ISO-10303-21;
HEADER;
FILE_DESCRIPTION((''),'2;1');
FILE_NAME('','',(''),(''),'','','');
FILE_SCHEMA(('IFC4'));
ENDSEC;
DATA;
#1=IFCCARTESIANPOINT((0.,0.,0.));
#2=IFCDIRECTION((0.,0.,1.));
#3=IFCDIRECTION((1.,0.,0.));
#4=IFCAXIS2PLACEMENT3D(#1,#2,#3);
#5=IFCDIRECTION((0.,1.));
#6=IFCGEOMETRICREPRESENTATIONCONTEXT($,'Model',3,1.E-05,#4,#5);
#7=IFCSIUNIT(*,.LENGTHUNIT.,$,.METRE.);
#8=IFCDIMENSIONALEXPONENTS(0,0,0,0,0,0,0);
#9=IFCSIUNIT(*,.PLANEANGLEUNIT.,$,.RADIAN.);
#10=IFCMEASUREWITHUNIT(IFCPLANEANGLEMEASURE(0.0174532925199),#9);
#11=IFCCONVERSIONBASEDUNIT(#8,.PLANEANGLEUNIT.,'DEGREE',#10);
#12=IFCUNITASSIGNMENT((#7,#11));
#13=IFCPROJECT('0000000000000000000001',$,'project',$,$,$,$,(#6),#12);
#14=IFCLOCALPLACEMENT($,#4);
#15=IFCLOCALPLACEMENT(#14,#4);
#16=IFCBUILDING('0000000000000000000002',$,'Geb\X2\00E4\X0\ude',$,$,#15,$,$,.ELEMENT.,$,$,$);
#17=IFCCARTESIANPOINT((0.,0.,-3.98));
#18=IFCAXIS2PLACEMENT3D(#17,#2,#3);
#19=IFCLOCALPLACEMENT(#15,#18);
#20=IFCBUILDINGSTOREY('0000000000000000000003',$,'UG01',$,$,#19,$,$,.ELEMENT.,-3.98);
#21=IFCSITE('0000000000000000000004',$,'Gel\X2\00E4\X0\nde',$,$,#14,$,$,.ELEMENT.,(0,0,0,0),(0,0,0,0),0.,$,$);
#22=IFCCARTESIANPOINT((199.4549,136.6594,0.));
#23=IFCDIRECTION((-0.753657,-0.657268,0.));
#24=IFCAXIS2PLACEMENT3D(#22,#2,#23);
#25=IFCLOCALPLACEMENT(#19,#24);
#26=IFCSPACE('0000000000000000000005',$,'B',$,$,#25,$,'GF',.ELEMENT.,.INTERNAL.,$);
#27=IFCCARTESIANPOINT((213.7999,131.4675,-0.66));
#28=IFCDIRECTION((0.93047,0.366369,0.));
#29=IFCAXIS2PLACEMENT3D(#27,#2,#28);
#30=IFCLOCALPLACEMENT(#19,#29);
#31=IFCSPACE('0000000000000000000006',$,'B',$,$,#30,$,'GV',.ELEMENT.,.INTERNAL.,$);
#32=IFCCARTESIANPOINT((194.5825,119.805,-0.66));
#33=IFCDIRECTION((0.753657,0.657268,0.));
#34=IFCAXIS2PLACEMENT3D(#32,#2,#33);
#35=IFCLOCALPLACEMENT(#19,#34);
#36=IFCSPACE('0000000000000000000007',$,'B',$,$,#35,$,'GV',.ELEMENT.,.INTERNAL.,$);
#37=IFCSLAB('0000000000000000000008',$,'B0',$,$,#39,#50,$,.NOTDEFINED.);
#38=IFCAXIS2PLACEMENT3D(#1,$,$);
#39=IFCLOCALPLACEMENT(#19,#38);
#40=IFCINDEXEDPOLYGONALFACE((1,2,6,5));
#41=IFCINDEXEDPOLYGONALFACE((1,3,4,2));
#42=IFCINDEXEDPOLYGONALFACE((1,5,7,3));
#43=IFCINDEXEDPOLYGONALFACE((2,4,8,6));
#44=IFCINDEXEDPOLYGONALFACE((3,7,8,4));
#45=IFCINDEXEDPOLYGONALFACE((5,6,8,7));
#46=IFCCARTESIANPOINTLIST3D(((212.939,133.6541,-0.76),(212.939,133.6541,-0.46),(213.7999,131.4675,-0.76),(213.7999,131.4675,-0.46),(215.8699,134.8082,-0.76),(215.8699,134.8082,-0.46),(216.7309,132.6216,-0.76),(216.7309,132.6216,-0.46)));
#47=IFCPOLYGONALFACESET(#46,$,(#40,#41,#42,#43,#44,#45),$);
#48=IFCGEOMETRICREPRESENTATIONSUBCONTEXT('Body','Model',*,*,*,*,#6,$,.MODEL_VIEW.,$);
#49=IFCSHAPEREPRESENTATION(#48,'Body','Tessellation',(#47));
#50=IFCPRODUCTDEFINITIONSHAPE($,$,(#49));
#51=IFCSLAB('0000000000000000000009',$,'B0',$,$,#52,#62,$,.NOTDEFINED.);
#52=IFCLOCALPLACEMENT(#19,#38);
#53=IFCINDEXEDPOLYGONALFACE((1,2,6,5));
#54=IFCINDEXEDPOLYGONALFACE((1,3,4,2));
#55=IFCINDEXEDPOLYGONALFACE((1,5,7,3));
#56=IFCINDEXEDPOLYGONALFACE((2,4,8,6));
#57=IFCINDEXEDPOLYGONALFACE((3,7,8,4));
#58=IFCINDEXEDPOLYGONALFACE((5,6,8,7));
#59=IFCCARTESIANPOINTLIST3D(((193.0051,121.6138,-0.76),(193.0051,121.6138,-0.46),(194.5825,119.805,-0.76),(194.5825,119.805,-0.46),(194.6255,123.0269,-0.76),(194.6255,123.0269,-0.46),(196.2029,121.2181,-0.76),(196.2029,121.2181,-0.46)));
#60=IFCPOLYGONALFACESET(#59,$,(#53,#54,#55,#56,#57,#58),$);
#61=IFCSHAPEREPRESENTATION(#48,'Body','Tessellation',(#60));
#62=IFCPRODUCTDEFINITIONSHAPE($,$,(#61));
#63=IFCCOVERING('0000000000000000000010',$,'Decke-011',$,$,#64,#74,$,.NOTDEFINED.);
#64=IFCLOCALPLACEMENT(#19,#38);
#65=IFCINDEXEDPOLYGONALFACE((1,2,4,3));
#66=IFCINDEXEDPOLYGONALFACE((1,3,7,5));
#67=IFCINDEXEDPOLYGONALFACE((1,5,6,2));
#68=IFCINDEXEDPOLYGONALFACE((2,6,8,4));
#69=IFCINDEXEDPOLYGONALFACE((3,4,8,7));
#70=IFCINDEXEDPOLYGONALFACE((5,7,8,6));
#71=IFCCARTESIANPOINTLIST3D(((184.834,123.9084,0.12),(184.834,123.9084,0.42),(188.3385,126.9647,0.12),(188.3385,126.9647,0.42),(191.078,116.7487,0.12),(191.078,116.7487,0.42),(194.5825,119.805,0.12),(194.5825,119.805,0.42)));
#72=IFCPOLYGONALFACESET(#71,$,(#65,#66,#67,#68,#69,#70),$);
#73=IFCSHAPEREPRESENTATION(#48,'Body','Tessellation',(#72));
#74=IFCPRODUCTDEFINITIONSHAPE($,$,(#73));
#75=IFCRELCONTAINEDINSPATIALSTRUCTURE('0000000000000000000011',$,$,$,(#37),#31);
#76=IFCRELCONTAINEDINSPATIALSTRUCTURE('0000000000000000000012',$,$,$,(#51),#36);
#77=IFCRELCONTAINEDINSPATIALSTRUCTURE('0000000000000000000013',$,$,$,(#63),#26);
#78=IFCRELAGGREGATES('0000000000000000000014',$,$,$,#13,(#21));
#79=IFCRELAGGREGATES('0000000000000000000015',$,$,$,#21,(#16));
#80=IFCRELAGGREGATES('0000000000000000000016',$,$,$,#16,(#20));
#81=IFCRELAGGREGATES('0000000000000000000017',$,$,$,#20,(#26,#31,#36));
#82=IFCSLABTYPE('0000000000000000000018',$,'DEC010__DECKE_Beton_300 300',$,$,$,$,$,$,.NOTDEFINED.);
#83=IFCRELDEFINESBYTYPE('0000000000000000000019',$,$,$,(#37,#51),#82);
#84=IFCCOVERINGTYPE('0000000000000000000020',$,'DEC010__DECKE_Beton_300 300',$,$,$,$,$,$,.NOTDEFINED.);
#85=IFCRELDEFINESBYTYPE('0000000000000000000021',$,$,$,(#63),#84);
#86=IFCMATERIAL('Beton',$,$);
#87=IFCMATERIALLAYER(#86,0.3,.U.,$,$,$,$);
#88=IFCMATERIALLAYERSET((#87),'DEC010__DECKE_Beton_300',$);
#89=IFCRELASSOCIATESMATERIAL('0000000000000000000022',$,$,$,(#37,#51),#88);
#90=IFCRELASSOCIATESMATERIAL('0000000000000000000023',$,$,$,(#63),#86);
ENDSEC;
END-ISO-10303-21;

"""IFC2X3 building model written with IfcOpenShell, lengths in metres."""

from ifc_helpers import new_model, entity, si_unit, converted_unit, direction, frame, origin_with_axes, place, context, subcontext, project, spatial, polyline, outline, extrude, material, layer, layer_set, layer_usage, type_object, element, save


model = new_model("IFC2X3")

# Units and contexts
model_context = context("Model", 3, precision=1e-05, world=origin_with_axes(), true_north=direction((0.0, 1.0)))
body_context = subcontext(model_context, "Body", "Model", "MODEL_VIEW")
ifc_project = project(units=[si_unit("LENGTHUNIT", "METRE"), converted_unit("PLANEANGLEUNIT", "DEGREE", entity("IfcPlaneAngleMeasure", 0.0174532925199), si_unit("PLANEANGLEUNIT", "RADIAN"), dimensions=[0, 0, 0, 0, 0, 0, 0])], contexts=[model_context])

# Site, building, storey, space
site_placement = place(None, origin_with_axes())
site = spatial("IfcSite", under=ifc_project, at=site_placement, Name="Gelände", CompositionType="ELEMENT", RefLatitude=(0, 0, 0, 0), RefLongitude=(0, 0, 0, 0), RefElevation=0.0)
building_placement = place(site_placement, origin_with_axes())
building = spatial("IfcBuilding", under=site, at=building_placement, Name="Gebäude", CompositionType="ELEMENT")
storey_placement = place(building_placement, frame((0.0, 0.0, -3.98), z_axis=(0.0, 0.0, 1.0), x_axis=(1.0, 0.0, 0.0)))
storey = spatial("IfcBuildingStorey", under=building, at=storey_placement, Name="UG01", CompositionType="ELEMENT", Elevation=-3.98)
space_1_placement = place(storey_placement, frame((199.4549, 136.6594, 0.0), z_axis=(0.0, 0.0, 1.0), x_axis=(-0.753657, -0.657268, 0.0)))
space_1 = spatial("IfcSpace", under=storey, at=space_1_placement, Name="B", LongName="GF", CompositionType="ELEMENT", InteriorOrExteriorSpace="INTERNAL")

# Shared definitions
ifc_material_1 = material(Name="Beton")

# Shared definitions
space_2_placement = place(storey_placement, frame((213.7999, 131.4675, -0.66), z_axis=(0.0, 0.0, 1.0), x_axis=(0.93047, 0.366369, 0.0)))
space_2 = spatial("IfcSpace", under=storey, at=space_2_placement, Name="B", LongName="GV", CompositionType="ELEMENT", InteriorOrExteriorSpace="INTERNAL")

# Slab
ifc_layer_1 = layer(ifc_material_1, 0.3, ventilated="UNKNOWN")
ifc_layer_set_1 = layer_set([ifc_layer_1], Name="DEC010__DECKE_Beton_300")
ifc_layer_usage_1 = layer_usage(ifc_layer_set_1, "AXIS3", "NEGATIVE", 0.3)
slab_type_1 = type_object("IfcSlabType", Name="DEC010__DECKE_Beton_300 300", PredefinedType="NOTDEFINED")
slab_1_placement = place(space_2_placement, frame((3.15, 0.0, 0.2), z_axis=(0.0, 0.0, 1.0), x_axis=(0.93047, -0.366369, 0.0)))
element("IfcSlab", 1, at=slab_1_placement, inside=space_2, type_object=slab_type_1, material=ifc_layer_usage_1, Name="B0", PredefinedType="NOTDEFINED", context=body_context, shape_type="SweptSolid", body=[
    extrude(outline(polyline([(0.0, 0.0), (-0.861, 2.1866), (-3.792, 1.0325), (-2.931, -1.1541), (0.0, 0.0)])), frame((0.0, 0.0, -0.3), z_axis=(0.0, 0.0, 1.0), x_axis=(1.0, 0.0, 0.0)), (0.0, 0.0, 1.0), 0.3),
])

# Shared definitions
space_3_placement = place(storey_placement, frame((194.5825, 119.805, -0.66), z_axis=(0.0, 0.0, 1.0), x_axis=(0.753657, 0.657268, 0.0)))
space_3 = spatial("IfcSpace", under=storey, at=space_3_placement, Name="B", LongName="GV", CompositionType="ELEMENT", InteriorOrExteriorSpace="INTERNAL")

# Slab
slab_2_placement = place(space_3_placement, frame((0.0, 2.4, 0.2), z_axis=(0.0, 0.0, 1.0), x_axis=(0.753657, -0.657268, 0.0)))
element("IfcSlab", 2, at=slab_2_placement, inside=space_3, type_object=slab_type_1, material=ifc_layer_usage_1, Name="B0", PredefinedType="NOTDEFINED", context=body_context, shape_type="SweptSolid", body=[
    extrude(outline(polyline([(0.0, 0.0), (1.5774, -1.8088), (3.1978, -0.3956), (1.6204, 1.4131), (0.0, 0.0)])), frame((0.0, 0.0, -0.3), z_axis=(0.0, 0.0, 1.0), x_axis=(1.0, 0.0, 0.0)), (0.0, 0.0, 1.0), 0.3),
])

# Covering
covering_type = type_object("IfcCoveringType", Name="DEC010__DECKE_Beton_300 300", PredefinedType="NOTDEFINED")
covering_placement = place(space_1_placement, frame((19.4, 0.0, 0.42), z_axis=(0.0, 0.0, 1.0), x_axis=(-0.753657, 0.657268, 0.0)))
element("IfcCovering", 3, at=covering_placement, inside=space_1, type_object=covering_type, material=ifc_material_1, Name="Decke-011", PredefinedType="NOTDEFINED", context=body_context, shape_type="SweptSolid", body=[
    extrude(outline(polyline([(0.0, 0.0), (6.244, -7.1597), (9.7486, -4.1034), (3.5045, 3.0563), (0.0, 0.0)])), frame((0.0, 0.0, -0.3), z_axis=(0.0, 0.0, 1.0), x_axis=(1.0, 0.0, 0.0)), (0.0, 0.0, 1.0), 0.3),
])

save(model, "model.ifc")
